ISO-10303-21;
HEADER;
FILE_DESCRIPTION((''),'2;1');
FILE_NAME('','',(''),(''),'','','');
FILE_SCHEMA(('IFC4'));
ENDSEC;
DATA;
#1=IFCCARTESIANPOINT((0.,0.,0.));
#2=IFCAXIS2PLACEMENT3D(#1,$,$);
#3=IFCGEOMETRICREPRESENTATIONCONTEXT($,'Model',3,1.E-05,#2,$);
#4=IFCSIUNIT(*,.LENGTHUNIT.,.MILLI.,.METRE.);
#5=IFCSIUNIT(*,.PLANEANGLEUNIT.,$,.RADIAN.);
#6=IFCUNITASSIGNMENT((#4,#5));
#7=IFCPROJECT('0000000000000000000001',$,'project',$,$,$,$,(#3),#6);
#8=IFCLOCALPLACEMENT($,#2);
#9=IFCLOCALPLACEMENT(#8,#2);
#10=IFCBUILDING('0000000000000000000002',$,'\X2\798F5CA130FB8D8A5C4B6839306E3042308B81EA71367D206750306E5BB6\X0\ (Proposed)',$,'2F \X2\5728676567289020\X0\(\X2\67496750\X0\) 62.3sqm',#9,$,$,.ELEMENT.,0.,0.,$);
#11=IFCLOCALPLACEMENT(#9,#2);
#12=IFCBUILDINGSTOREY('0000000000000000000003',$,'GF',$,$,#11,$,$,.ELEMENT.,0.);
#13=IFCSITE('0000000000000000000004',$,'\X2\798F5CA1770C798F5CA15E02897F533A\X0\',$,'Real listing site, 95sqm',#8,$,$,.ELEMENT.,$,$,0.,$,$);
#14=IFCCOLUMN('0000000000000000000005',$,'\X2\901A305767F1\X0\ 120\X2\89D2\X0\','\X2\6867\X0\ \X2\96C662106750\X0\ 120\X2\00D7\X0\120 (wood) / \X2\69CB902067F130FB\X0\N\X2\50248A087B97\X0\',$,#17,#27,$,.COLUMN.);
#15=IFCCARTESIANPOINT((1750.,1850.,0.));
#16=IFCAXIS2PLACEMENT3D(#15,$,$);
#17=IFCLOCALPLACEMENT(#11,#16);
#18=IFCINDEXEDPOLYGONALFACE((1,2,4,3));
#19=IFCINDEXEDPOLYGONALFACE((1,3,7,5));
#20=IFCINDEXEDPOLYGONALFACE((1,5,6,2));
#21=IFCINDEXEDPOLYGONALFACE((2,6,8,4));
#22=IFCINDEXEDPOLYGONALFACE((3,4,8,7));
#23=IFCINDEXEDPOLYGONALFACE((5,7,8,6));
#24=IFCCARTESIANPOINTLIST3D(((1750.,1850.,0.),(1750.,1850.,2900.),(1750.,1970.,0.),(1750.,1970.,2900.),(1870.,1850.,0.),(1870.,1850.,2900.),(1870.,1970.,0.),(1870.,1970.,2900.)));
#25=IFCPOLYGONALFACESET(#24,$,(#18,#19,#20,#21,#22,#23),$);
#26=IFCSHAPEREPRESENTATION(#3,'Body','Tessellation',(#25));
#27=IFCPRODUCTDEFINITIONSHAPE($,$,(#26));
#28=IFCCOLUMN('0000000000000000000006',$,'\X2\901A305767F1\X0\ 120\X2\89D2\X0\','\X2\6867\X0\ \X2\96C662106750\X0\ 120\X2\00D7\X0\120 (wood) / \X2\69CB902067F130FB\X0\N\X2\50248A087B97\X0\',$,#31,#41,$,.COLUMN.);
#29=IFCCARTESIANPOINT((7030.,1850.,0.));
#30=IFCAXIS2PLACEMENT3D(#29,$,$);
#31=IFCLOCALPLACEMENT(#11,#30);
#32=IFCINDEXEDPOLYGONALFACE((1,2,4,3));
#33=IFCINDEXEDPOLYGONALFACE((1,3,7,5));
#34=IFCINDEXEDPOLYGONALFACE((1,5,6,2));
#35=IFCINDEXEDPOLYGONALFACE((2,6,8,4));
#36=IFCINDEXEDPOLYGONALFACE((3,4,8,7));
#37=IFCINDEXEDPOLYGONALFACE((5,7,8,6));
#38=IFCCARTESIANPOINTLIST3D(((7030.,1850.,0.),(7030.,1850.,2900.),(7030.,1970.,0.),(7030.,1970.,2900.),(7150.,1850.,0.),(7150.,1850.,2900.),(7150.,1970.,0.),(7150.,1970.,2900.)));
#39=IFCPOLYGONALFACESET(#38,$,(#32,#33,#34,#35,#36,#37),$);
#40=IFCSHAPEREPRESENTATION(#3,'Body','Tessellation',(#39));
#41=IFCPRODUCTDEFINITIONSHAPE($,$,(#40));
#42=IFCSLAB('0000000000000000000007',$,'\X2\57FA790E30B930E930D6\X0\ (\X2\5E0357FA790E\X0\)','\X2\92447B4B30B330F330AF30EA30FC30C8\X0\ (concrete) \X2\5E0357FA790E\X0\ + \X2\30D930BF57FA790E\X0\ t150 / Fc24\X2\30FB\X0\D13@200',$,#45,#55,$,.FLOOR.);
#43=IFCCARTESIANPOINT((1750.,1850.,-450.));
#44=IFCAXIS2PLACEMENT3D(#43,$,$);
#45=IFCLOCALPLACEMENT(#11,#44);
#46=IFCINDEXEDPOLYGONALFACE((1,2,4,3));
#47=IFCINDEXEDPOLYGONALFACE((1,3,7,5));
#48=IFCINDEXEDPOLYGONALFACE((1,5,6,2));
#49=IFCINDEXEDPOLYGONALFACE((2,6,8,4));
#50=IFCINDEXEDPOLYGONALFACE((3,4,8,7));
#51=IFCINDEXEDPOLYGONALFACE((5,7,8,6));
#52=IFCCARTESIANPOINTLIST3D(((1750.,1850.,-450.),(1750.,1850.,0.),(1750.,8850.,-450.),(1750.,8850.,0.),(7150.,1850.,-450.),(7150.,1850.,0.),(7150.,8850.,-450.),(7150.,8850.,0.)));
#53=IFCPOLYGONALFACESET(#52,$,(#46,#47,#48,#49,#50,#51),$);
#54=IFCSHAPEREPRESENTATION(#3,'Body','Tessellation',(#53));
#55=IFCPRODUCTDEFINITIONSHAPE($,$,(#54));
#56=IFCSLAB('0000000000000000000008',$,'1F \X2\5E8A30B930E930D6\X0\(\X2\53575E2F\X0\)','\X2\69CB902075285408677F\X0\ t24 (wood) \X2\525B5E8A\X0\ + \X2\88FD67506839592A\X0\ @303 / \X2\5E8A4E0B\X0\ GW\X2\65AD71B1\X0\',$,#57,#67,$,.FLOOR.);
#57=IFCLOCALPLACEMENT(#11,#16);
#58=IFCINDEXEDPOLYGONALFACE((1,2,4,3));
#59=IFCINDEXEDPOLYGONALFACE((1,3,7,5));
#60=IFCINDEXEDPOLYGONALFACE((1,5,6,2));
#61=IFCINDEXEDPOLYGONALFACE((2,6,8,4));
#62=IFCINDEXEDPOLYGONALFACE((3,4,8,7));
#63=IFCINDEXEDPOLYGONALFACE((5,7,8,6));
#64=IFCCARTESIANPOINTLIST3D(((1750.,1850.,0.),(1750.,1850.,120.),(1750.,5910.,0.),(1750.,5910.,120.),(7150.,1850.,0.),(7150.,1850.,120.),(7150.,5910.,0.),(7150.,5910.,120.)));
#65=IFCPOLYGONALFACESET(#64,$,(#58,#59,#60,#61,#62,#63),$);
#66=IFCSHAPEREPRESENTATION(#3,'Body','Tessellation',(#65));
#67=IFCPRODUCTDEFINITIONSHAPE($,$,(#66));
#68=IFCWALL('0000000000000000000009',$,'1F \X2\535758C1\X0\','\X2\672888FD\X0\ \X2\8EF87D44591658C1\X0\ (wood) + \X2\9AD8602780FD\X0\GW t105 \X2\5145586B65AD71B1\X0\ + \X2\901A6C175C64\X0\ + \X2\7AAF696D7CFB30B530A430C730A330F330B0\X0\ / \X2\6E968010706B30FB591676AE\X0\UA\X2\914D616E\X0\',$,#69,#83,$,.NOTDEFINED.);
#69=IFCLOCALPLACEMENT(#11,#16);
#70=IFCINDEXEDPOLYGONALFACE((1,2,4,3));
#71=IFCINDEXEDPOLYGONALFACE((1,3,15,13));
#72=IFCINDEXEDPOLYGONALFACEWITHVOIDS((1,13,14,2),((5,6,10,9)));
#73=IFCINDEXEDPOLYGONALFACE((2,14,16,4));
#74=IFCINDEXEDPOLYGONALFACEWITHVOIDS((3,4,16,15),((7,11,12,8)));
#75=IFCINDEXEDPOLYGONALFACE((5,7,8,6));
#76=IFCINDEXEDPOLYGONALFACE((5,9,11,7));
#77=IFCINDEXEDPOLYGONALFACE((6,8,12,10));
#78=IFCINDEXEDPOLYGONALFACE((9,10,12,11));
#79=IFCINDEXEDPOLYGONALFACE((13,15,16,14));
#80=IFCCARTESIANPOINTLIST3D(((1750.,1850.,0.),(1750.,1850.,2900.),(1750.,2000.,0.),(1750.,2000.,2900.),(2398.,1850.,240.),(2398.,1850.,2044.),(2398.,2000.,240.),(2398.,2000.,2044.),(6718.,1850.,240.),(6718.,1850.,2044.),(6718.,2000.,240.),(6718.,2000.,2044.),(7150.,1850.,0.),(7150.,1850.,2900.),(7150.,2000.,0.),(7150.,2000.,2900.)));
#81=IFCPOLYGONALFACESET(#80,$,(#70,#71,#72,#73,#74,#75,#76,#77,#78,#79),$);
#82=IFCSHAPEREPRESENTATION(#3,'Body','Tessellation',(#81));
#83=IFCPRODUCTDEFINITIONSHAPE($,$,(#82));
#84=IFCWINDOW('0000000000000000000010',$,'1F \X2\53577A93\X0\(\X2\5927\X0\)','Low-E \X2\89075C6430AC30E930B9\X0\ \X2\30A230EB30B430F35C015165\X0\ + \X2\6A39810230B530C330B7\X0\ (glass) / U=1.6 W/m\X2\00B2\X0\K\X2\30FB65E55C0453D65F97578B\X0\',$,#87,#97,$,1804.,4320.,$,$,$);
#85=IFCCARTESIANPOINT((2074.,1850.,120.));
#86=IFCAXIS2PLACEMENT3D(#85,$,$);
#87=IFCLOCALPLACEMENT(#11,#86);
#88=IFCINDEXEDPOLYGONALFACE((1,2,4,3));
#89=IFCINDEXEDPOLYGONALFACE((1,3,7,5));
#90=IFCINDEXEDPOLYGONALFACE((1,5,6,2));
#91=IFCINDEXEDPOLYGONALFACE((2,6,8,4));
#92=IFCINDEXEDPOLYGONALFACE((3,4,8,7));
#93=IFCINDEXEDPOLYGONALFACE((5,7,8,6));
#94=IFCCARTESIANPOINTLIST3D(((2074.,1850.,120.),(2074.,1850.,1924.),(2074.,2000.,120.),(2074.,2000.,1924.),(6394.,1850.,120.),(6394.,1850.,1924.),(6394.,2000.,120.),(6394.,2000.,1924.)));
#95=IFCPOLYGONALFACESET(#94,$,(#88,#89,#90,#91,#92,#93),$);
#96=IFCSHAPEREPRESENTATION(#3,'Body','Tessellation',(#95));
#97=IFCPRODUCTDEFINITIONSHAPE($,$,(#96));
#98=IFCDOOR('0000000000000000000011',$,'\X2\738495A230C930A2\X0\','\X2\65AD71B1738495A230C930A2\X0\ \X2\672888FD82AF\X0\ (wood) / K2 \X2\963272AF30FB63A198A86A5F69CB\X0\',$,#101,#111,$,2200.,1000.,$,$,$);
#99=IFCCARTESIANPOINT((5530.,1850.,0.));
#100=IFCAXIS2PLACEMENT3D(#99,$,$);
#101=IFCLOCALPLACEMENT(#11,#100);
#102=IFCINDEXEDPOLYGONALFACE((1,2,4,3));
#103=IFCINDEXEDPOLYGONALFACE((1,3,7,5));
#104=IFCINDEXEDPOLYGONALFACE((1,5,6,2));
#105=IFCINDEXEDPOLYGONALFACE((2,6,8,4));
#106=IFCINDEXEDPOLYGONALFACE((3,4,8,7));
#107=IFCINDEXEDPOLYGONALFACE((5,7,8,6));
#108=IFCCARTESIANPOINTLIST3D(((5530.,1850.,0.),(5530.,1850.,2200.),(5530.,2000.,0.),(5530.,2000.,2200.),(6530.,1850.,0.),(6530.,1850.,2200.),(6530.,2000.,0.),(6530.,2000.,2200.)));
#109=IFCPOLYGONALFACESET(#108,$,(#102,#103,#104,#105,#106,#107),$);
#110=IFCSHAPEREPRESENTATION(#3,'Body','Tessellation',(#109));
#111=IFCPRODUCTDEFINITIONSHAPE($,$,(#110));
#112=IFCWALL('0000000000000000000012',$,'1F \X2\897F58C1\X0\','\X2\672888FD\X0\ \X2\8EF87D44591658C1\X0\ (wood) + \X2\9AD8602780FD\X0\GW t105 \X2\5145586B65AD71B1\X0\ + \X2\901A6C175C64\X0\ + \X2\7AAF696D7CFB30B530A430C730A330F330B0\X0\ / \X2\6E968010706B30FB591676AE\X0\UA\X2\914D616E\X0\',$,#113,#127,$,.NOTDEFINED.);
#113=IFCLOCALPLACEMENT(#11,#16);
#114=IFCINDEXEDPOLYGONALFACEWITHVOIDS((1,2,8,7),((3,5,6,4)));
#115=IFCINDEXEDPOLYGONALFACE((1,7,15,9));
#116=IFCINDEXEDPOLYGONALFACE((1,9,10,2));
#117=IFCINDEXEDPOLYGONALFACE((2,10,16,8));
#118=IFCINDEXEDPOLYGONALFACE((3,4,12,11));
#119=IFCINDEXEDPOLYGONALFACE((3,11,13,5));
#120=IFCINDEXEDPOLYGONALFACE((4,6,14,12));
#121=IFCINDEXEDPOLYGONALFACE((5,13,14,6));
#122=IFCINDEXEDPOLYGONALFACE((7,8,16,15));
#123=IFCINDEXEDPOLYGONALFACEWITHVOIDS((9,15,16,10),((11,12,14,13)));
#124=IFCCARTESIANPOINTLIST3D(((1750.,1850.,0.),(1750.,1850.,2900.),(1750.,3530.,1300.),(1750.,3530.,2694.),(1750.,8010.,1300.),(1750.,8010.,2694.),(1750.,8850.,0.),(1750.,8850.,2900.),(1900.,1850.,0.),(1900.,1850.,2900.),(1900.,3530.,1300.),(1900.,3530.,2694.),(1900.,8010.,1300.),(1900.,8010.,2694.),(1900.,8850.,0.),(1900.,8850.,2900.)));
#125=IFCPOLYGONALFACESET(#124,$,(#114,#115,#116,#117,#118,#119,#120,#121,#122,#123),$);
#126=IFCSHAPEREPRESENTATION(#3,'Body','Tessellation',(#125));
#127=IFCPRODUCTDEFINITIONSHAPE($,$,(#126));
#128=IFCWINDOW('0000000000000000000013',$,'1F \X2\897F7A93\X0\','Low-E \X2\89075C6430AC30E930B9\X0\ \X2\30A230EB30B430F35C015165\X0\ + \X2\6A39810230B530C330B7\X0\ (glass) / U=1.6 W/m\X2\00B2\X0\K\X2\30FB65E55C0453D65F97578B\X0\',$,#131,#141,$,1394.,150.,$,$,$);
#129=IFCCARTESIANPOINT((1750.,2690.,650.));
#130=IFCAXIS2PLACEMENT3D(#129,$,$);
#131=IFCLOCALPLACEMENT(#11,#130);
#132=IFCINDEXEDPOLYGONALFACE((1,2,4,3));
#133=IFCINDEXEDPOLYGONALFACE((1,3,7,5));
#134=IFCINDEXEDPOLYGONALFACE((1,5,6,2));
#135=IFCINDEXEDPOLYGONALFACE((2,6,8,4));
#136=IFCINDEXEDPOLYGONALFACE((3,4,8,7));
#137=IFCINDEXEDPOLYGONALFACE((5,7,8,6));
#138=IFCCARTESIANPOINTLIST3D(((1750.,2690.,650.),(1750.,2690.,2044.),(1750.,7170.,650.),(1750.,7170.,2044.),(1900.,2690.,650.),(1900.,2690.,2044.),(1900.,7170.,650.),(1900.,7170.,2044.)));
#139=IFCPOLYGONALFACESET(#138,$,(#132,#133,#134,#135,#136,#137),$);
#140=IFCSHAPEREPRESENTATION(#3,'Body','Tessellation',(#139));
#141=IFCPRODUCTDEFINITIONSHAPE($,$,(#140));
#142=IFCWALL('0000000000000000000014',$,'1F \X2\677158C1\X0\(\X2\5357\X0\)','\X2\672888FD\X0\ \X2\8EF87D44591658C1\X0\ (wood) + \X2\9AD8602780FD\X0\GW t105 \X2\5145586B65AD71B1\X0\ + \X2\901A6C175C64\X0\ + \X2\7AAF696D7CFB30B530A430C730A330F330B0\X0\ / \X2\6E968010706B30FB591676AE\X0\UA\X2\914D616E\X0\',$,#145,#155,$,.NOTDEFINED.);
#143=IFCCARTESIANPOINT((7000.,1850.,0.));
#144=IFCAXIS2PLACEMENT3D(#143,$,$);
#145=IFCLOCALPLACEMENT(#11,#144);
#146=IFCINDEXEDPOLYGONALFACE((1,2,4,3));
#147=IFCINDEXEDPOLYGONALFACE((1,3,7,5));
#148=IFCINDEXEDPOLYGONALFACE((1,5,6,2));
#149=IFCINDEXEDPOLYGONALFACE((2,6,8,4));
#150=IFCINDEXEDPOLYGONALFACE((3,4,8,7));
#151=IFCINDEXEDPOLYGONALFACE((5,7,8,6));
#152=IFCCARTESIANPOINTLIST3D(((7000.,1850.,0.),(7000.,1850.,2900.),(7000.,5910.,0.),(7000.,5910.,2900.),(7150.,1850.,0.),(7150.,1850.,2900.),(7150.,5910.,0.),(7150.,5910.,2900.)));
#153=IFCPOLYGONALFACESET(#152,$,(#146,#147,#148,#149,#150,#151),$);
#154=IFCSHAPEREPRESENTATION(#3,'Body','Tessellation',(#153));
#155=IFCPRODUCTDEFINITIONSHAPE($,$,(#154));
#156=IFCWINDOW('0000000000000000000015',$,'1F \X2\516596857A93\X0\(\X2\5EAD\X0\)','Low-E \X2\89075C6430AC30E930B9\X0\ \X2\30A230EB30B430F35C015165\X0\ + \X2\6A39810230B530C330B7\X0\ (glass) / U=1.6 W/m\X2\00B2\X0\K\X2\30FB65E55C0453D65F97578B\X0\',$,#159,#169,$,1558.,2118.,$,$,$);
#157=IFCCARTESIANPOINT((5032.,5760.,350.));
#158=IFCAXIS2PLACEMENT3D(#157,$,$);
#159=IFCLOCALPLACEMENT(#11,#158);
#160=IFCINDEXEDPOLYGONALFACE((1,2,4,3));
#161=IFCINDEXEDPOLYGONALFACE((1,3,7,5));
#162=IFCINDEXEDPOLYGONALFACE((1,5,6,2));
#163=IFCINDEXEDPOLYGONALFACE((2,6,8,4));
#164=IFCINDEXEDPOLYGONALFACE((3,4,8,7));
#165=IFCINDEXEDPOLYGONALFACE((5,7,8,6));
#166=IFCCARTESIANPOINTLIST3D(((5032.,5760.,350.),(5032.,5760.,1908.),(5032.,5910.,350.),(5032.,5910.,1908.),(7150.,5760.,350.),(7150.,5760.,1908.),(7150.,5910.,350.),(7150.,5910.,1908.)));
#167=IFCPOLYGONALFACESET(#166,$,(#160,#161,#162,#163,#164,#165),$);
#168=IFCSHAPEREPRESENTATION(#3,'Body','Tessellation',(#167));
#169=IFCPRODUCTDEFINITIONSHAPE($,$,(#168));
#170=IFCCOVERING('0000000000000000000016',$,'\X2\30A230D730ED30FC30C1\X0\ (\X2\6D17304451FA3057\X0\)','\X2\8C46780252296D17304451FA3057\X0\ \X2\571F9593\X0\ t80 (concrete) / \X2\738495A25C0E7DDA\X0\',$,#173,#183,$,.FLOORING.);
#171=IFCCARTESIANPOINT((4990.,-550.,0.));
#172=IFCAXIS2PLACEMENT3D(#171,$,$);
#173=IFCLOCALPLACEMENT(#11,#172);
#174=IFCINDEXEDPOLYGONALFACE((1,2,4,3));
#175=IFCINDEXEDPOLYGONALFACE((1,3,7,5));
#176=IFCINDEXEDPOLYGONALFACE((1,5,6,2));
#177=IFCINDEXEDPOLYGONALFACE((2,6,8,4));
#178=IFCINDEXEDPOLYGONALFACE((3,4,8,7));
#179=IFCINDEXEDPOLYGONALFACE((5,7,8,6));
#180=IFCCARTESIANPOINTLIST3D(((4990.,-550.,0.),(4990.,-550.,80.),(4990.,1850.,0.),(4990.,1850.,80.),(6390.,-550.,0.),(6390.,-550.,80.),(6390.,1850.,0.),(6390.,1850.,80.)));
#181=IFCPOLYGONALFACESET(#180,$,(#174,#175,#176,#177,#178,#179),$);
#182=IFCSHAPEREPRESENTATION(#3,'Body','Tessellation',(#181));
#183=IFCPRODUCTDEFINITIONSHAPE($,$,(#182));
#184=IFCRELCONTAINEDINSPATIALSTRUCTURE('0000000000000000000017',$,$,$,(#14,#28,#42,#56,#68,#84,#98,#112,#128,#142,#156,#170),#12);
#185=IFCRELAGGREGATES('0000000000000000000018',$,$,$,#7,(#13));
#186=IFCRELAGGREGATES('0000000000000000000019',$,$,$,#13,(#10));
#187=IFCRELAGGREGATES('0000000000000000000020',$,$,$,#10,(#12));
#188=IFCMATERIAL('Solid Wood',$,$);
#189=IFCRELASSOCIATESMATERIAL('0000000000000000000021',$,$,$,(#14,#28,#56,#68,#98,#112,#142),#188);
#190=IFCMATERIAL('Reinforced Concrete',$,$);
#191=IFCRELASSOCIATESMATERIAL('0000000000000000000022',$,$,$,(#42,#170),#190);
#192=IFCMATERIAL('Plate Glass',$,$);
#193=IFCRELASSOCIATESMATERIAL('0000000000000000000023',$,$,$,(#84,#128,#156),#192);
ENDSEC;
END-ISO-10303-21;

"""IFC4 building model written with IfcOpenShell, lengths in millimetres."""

from ifc_helpers import new_model, si_unit, frame, frame_2d, origin, place, context, project, spatial, rectangle, extrude, material, element, fill, save


model = new_model("IFC4")

# Units and contexts
model_context = context("Model", 3, precision=1e-05, world=origin())
ifc_project = project(units=[si_unit("LENGTHUNIT", "METRE", prefix="MILLI"), si_unit("PLANEANGLEUNIT", "RADIAN")], contexts=[model_context])

# Site, building, storey
site_placement = place(None, origin())
site = spatial("IfcSite", under=ifc_project, at=site_placement, Name="福岡県福岡市西区", ObjectType="Real listing site, 95sqm", CompositionType="ELEMENT", RefElevation=0.0)
building_placement = place(site_placement, origin())
building = spatial("IfcBuilding", under=site, at=building_placement, Name="福岡・越屋根のある自然素材の家 (Proposed)", ObjectType="2F 在来木造(杉材) 62.3sqm", CompositionType="ELEMENT", ElevationOfRefHeight=0.0, ElevationOfTerrain=0.0)
storey_placement = place(building_placement, origin())
storey = spatial("IfcBuildingStorey", under=building, at=storey_placement, Name="GF", CompositionType="ELEMENT", Elevation=0.0)

# Columns
ifc_material_1 = material(Name="Solid Wood")
column_1_placement = place(storey_placement, frame((1750.0, 1850.0, 0.0)))
element("IfcColumn", 1, at=column_1_placement, inside=storey, material=ifc_material_1, Name="通し柱 120角", Description="桧 集成材 120×120 (wood) / 構造柱・N値計算", PredefinedType="COLUMN", context=model_context, shape_type="SweptSolid", body=[
    extrude(rectangle(XDim=120.0, YDim=120.0, at=frame_2d((60.0, 60.0))), frame((1750.0, 1850.0, 0.0)), (0.0, 0.0, 1.0), 2900.0),
])
column_2_placement = place(storey_placement, frame((7030.0, 1850.0, 0.0)))
element("IfcColumn", 2, at=column_2_placement, inside=storey, material=ifc_material_1, Name="通し柱 120角", Description="桧 集成材 120×120 (wood) / 構造柱・N値計算", PredefinedType="COLUMN", context=model_context, shape_type="SweptSolid", body=[
    extrude(rectangle(XDim=120.0, YDim=120.0, at=frame_2d((60.0, 60.0))), frame((7030.0, 1850.0, 0.0)), (0.0, 0.0, 1.0), 2900.0),
])

# Slabs
ifc_material_2 = material(Name="Reinforced Concrete")
slab_1_placement = place(storey_placement, frame((1750.0, 1850.0, -450.0)))
element("IfcSlab", 3, at=slab_1_placement, inside=storey, material=ifc_material_2, Name="基礎スラブ (布基礎)", Description="鉄筋コンクリート (concrete) 布基礎 + ベタ基礎 t150 / Fc24・D13@200", PredefinedType="FLOOR", context=model_context, shape_type="SweptSolid", body=[
    extrude(rectangle(XDim=5400.0, YDim=7000.0, at=frame_2d((2700.0, 3500.0))), frame((1750.0, 1850.0, -450.0)), (0.0, 0.0, 1.0), 450.0),
])
slab_2_placement = place(storey_placement, frame((1750.0, 1850.0, 0.0)))
element("IfcSlab", 4, at=slab_2_placement, inside=storey, material=ifc_material_1, Name="1F 床スラブ(南帯)", Description="構造用合板 t24 (wood) 剛床 + 製材根太 @303 / 床下 GW断熱", PredefinedType="FLOOR", context=model_context, shape_type="SweptSolid", body=[
    extrude(rectangle(XDim=5400.0, YDim=4060.0, at=frame_2d((2700.0, 2030.0))), frame((1750.0, 1850.0, 0.0)), (0.0, 0.0, 1.0), 120.0),
])

# Wall, openings, window, door
wall_1_placement = place(storey_placement, frame((1750.0, 1850.0, 0.0)))
wall_1 = element("IfcWall", 5, at=wall_1_placement, inside=storey, material=ifc_material_1, Name="1F 南壁", Description="木製 軸組外壁 (wood) + 高性能GW t105 充填断熱 + 通気層 + 窯業系サイディング / 準耐火・外皮UA配慮", PredefinedType="NOTDEFINED", context=model_context, shape_type="SweptSolid", body=[
    extrude(rectangle(XDim=5400.0, YDim=150.0, at=frame_2d((2700.0, 75.0))), frame((1750.0, 1850.0, 0.0)), (0.0, 0.0, 1.0), 2900.0),
])
opening_1_placement = place(storey_placement, frame((2074.0, 1850.0, 120.0)))
opening_1 = element("IfcOpeningElement", 6, at=opening_1_placement, cuts=wall_1, PredefinedType="NOTDEFINED", context=model_context, shape_type="SweptSolid", body=[
    extrude(rectangle(XDim=4320.0, YDim=150.0, at=frame_2d((2160.0, 75.0))), frame((2074.0, 1850.0, 120.0)), (0.0, 0.0, 1.0), 1804.0),
])
opening_2_placement = place(storey_placement, frame((5530.0, 1850.0, 0.0)))
opening_2 = element("IfcOpeningElement", 7, at=opening_2_placement, cuts=wall_1, PredefinedType="NOTDEFINED", context=model_context, shape_type="SweptSolid", body=[
    extrude(rectangle(XDim=1000.0, YDim=150.0, at=frame_2d((500.0, 75.0))), frame((5530.0, 1850.0, 0.0)), (0.0, 0.0, 1.0), 2200.0),
])
ifc_material_3 = material(Name="Plate Glass")
window_1_placement = place(storey_placement, frame((2074.0, 1850.0, 120.0)))
window_1 = element("IfcWindow", 8, at=window_1_placement, inside=storey, material=ifc_material_3, Name="1F 南窓(大)", Description="Low-E 複層ガラス アルゴン封入 + 樹脂サッシ (glass) / U=1.6 W/m²K・日射取得型", OverallHeight=1804.0, OverallWidth=4320.0, context=model_context, shape_type="SweptSolid", body=[
    extrude(rectangle(XDim=4320.0, YDim=150.0, at=frame_2d((2160.0, 75.0))), frame((2074.0, 1850.0, 120.0)), (0.0, 0.0, 1.0), 1804.0),
])
fill(opening_1, window_1)
door_1_placement = place(storey_placement, frame((5530.0, 1850.0, 0.0)))
door_1 = element("IfcDoor", 9, at=door_1_placement, inside=storey, material=ifc_material_1, Name="玄関ドア", Description="断熱玄関ドア 木製芯 (wood) / K2 防犯・採風機構", OverallHeight=2200.0, OverallWidth=1000.0, context=model_context, shape_type="SweptSolid", body=[
    extrude(rectangle(XDim=1000.0, YDim=150.0, at=frame_2d((500.0, 75.0))), frame((5530.0, 1850.0, 0.0)), (0.0, 0.0, 1.0), 2200.0),
])
fill(opening_2, door_1)

# Walls, openings, windows
wall_2_placement = place(storey_placement, frame((1750.0, 1850.0, 0.0)))
wall_2 = element("IfcWall", 10, at=wall_2_placement, inside=storey, material=ifc_material_1, Name="1F 西壁", Description="木製 軸組外壁 (wood) + 高性能GW t105 充填断熱 + 通気層 + 窯業系サイディング / 準耐火・外皮UA配慮", PredefinedType="NOTDEFINED", context=model_context, shape_type="SweptSolid", body=[
    extrude(rectangle(XDim=150.0, YDim=7000.0, at=frame_2d((75.0, 3500.0))), frame((1750.0, 1850.0, 0.0)), (0.0, 0.0, 1.0), 2900.0),
])
opening_3_placement = place(storey_placement, frame((1750.0, 2690.0, 650.0)))
opening_3 = element("IfcOpeningElement", 11, at=opening_3_placement, cuts=wall_2, PredefinedType="NOTDEFINED", context=model_context, shape_type="SweptSolid", body=[
    extrude(rectangle(XDim=150.0, YDim=4480.0, at=frame_2d((75.0, 2240.0))), frame((1750.0, 2690.0, 650.0)), (0.0, 0.0, 1.0), 1394.0),
])
window_2_placement = place(storey_placement, frame((1750.0, 2690.0, 650.0)))
window_2 = element("IfcWindow", 12, at=window_2_placement, inside=storey, material=ifc_material_3, Name="1F 西窓", Description="Low-E 複層ガラス アルゴン封入 + 樹脂サッシ (glass) / U=1.6 W/m²K・日射取得型", OverallHeight=1394.0, OverallWidth=150.0, context=model_context, shape_type="SweptSolid", body=[
    extrude(rectangle(XDim=150.0, YDim=4480.0, at=frame_2d((75.0, 2240.0))), frame((1750.0, 2690.0, 650.0)), (0.0, 0.0, 1.0), 1394.0),
])
fill(opening_3, window_2)
wall_3_placement = place(storey_placement, frame((7000.0, 1850.0, 0.0)))
wall_3 = element("IfcWall", 13, at=wall_3_placement, inside=storey, material=ifc_material_1, Name="1F 東壁(南)", Description="木製 軸組外壁 (wood) + 高性能GW t105 充填断熱 + 通気層 + 窯業系サイディング / 準耐火・外皮UA配慮", PredefinedType="NOTDEFINED", context=model_context, shape_type="SweptSolid", body=[
    extrude(rectangle(XDim=150.0, YDim=4060.0, at=frame_2d((75.0, 2030.0))), frame((7000.0, 1850.0, 0.0)), (0.0, 0.0, 1.0), 2900.0),
])
opening_4_placement = place(storey_placement, frame((5032.0, 5760.0, 350.0)))
opening_4 = element("IfcOpeningElement", 14, at=opening_4_placement, cuts=wall_3, PredefinedType="NOTDEFINED", context=model_context, shape_type="SweptSolid", body=[
    extrude(rectangle(XDim=2118.0, YDim=150.0, at=frame_2d((1059.0, 75.0))), frame((5032.0, 5760.0, 350.0)), (0.0, 0.0, 1.0), 1558.0),
])
window_3_placement = place(storey_placement, frame((5032.0, 5760.0, 350.0)))
window_3 = element("IfcWindow", 15, at=window_3_placement, inside=storey, material=ifc_material_3, Name="1F 入隅窓(庭)", Description="Low-E 複層ガラス アルゴン封入 + 樹脂サッシ (glass) / U=1.6 W/m²K・日射取得型", OverallHeight=1558.0, OverallWidth=2118.0, context=model_context, shape_type="SweptSolid", body=[
    extrude(rectangle(XDim=2118.0, YDim=150.0, at=frame_2d((1059.0, 75.0))), frame((5032.0, 5760.0, 350.0)), (0.0, 0.0, 1.0), 1558.0),
])
fill(opening_4, window_3)

# Covering
covering_1_placement = place(storey_placement, frame((4990.0, -550.0, 0.0)))
element("IfcCovering", 16, at=covering_1_placement, inside=storey, material=ifc_material_2, Name="アプローチ (洗い出し)", Description="豆砂利洗い出し 土間 t80 (concrete) / 玄関導線", PredefinedType="FLOORING", context=model_context, shape_type="SweptSolid", body=[
    extrude(rectangle(XDim=1400.0, YDim=2400.0, at=frame_2d((700.0, 1200.0))), frame((4990.0, -550.0, 0.0)), (0.0, 0.0, 1.0), 80.0),
])

save(model, "model.ifc")
